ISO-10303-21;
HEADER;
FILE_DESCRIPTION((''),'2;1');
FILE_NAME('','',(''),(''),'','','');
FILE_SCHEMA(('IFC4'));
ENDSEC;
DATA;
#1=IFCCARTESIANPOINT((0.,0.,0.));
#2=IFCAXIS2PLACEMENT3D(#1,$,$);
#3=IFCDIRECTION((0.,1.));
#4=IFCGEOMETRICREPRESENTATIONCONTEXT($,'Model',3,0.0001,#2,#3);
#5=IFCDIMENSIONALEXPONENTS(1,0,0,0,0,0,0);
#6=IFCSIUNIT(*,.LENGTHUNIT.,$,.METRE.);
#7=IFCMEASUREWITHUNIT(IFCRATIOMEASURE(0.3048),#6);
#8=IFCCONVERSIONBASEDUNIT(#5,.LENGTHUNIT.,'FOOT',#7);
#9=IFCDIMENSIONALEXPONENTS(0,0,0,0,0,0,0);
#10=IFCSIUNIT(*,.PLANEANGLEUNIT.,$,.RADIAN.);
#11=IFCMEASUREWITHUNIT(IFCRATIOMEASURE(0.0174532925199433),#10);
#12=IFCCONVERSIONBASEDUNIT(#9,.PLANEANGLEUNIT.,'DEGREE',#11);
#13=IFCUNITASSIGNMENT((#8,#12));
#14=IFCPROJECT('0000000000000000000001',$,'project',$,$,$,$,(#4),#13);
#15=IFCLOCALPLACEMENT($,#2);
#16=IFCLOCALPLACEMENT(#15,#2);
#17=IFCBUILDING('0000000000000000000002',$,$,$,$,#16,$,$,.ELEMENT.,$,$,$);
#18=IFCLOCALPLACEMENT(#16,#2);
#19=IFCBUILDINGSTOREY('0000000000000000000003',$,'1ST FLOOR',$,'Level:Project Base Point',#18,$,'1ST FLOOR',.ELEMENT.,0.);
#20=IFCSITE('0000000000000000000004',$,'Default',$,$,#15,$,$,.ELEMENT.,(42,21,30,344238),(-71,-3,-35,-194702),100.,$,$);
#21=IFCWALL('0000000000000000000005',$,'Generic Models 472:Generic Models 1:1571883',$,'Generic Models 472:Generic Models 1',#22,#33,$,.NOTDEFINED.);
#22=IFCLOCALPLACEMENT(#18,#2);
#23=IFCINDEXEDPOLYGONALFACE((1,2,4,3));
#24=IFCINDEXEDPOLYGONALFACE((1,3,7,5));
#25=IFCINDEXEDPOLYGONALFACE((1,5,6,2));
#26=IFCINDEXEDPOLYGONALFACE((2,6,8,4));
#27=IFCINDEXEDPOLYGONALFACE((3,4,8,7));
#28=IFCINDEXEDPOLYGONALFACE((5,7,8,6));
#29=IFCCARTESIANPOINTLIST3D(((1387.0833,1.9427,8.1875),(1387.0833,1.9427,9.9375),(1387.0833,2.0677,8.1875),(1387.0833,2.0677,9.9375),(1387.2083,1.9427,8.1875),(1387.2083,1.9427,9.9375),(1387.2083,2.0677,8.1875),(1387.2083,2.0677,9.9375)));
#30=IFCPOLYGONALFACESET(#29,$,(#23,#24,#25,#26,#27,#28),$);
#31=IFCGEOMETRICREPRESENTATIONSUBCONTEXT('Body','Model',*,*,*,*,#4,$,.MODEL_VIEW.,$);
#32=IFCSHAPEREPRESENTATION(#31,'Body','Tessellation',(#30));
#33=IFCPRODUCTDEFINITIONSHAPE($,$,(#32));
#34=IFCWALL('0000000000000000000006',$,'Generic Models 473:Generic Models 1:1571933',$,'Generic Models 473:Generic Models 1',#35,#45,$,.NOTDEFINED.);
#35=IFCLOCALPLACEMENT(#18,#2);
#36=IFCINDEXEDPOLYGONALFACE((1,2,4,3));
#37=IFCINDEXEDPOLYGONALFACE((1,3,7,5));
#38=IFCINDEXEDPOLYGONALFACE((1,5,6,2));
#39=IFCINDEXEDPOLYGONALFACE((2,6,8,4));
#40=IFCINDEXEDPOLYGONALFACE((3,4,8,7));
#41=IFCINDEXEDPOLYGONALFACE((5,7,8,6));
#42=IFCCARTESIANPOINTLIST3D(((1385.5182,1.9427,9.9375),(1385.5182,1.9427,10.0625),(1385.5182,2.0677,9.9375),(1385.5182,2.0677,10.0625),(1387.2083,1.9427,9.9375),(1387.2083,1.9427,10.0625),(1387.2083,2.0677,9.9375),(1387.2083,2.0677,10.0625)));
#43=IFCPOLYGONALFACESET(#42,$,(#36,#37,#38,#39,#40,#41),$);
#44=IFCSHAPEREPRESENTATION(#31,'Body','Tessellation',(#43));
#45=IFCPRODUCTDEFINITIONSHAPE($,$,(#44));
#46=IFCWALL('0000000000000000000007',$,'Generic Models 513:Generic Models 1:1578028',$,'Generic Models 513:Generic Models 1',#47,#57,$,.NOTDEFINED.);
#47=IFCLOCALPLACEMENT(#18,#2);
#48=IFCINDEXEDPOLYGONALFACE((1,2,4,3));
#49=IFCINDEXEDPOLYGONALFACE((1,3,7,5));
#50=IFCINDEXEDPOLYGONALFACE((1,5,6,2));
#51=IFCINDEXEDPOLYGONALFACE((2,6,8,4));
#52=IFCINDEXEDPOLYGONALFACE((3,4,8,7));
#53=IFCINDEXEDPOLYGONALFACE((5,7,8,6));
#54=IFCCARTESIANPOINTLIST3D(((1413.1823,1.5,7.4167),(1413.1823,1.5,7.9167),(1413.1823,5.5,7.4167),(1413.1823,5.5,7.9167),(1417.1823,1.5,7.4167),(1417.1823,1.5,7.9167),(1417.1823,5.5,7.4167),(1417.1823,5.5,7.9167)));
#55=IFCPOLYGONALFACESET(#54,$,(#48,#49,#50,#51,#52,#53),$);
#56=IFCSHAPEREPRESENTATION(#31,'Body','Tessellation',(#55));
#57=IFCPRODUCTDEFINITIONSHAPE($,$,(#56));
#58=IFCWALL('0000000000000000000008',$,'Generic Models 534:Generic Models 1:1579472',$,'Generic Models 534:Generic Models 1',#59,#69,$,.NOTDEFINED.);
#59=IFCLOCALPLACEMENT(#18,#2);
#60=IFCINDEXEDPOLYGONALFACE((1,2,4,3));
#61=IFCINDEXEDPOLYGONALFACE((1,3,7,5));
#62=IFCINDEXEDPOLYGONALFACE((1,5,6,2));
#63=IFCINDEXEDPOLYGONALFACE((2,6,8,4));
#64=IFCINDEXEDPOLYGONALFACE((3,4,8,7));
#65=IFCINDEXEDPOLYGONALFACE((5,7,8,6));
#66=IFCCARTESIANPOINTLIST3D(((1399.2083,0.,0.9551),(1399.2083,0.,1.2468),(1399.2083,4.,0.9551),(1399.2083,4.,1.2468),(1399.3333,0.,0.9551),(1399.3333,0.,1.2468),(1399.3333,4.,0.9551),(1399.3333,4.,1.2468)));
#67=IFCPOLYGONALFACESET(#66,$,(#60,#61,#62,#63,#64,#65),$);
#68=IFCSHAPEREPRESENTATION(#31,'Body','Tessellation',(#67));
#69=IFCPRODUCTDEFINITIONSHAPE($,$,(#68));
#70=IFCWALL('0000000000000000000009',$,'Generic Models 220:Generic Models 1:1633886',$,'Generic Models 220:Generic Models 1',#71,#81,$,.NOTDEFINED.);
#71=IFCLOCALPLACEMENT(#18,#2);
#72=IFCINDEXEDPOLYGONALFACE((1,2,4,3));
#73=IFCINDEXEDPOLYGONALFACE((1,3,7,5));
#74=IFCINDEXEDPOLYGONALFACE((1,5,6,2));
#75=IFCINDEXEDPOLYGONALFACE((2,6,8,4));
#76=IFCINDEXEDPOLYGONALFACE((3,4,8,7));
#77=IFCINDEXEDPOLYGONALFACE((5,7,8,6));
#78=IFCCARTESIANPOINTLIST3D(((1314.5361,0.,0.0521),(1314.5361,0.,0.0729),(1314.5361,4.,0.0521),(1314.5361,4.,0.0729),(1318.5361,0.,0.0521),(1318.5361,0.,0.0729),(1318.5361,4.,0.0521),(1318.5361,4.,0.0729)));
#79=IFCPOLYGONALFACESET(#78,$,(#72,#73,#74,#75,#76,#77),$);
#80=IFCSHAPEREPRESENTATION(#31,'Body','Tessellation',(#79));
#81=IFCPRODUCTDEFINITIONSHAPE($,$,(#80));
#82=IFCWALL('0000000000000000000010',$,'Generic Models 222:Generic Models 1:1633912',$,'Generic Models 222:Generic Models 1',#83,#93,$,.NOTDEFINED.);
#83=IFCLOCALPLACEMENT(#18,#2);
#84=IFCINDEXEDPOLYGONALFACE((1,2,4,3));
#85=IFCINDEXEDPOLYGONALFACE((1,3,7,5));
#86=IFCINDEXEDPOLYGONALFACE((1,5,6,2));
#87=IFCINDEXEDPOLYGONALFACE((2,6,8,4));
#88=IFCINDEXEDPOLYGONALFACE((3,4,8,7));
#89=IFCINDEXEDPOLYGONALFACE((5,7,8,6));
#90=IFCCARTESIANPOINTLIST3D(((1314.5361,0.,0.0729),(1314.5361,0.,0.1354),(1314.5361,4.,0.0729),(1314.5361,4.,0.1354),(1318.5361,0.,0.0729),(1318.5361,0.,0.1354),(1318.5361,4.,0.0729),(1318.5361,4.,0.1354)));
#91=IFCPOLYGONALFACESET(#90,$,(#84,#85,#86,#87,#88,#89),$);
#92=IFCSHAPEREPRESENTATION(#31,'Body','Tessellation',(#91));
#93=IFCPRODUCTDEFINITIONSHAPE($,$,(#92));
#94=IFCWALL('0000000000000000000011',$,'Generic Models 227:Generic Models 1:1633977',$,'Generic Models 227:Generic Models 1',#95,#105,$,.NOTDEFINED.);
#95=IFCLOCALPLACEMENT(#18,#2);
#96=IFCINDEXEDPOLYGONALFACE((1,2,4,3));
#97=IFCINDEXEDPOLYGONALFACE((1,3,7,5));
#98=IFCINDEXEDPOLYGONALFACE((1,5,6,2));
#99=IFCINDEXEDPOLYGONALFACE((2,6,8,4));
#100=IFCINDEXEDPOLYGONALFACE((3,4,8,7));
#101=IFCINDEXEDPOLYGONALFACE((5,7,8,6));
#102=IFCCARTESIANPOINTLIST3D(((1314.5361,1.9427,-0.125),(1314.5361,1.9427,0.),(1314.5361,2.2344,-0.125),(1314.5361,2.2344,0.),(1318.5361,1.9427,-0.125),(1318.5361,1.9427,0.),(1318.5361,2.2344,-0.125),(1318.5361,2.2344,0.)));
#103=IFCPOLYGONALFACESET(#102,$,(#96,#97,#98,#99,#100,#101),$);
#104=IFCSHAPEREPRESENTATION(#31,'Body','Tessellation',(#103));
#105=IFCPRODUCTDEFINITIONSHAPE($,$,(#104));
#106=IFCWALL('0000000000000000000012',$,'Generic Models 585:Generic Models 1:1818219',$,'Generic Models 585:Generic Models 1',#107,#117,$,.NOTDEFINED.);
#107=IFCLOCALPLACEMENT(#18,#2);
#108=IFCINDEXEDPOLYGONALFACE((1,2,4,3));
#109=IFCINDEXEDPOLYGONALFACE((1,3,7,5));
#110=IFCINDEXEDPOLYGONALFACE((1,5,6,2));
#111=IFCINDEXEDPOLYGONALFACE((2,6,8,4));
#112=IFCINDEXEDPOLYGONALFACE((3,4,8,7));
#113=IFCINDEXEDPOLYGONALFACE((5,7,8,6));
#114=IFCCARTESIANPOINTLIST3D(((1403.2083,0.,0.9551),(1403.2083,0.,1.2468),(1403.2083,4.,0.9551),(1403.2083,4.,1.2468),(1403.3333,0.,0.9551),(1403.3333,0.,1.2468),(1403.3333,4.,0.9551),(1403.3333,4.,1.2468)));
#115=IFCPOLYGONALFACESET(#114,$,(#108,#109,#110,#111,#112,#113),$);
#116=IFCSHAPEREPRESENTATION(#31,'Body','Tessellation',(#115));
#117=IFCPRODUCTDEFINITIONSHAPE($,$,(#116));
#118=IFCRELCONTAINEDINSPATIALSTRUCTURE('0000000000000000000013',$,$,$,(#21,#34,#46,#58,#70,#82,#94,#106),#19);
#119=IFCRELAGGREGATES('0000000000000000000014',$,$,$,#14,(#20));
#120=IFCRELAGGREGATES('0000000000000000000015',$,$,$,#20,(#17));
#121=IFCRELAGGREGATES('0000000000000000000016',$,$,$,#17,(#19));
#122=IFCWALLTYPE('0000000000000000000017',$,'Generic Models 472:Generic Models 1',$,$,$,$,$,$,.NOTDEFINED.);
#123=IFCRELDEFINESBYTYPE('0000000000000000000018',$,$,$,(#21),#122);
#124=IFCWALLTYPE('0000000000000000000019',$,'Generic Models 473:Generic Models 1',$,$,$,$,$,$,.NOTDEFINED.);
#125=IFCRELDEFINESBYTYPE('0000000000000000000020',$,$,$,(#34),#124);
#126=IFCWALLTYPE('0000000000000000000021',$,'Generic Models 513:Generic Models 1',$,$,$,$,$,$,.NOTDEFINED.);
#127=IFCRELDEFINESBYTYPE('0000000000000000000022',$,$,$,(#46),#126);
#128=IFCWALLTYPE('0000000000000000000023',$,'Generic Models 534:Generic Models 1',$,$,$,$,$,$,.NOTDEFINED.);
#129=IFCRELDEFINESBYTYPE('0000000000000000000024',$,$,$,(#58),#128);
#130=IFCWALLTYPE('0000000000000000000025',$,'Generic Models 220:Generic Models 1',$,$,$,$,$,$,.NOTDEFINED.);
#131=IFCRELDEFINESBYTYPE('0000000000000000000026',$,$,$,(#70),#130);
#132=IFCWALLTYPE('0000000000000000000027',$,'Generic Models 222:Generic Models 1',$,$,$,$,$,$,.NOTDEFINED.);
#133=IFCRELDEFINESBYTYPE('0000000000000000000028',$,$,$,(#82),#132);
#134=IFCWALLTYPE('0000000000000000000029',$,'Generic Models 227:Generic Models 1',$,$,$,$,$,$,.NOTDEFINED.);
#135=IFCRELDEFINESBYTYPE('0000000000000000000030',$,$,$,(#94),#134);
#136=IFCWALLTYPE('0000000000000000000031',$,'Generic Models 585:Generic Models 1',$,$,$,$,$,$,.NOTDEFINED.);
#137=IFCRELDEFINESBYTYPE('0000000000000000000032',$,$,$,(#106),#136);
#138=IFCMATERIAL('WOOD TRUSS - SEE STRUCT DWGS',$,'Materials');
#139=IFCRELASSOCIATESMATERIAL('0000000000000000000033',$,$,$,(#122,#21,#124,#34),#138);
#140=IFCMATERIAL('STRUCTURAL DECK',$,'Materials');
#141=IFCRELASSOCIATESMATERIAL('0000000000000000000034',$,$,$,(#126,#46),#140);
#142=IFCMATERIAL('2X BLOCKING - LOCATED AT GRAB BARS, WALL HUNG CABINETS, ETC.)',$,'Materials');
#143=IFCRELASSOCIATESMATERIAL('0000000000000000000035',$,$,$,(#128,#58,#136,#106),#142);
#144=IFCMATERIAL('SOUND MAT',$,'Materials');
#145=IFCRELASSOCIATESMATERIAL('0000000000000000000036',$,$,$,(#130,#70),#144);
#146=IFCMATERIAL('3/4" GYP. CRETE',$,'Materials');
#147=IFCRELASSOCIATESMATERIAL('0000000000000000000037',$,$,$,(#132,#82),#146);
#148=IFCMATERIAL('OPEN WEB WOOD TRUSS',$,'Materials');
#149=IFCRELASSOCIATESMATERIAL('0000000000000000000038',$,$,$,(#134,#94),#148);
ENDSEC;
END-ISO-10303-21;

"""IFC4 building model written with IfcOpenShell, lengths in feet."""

from ifc_helpers import new_model, entity, si_unit, converted_unit, direction, frame, frame_2d, origin, origin_2d_with_axis, place, context, subcontext, project, spatial, rectangle, extrude, material, type_object, element, save


model = new_model("IFC4")

# Units and contexts
model_context = context("Model", 3, precision=0.0001, world=origin(), true_north=direction((0.0, 1.0)))
body_context = subcontext(model_context, "Body", "Model", "MODEL_VIEW")
ifc_project = project(units=[converted_unit("LENGTHUNIT", "FOOT", entity("IfcRatioMeasure", 0.3048), si_unit("LENGTHUNIT", "METRE"), dimensions=[1, 0, 0, 0, 0, 0, 0]), converted_unit("PLANEANGLEUNIT", "DEGREE", entity("IfcRatioMeasure", 0.0174532925199433), si_unit("PLANEANGLEUNIT", "RADIAN"), dimensions=[0, 0, 0, 0, 0, 0, 0])], contexts=[model_context])

# Site, building, storey
site_placement = place(None, origin())
site = spatial("IfcSite", under=ifc_project, at=site_placement, Name="Default", CompositionType="ELEMENT", RefLatitude=(42, 21, 30, 344238), RefLongitude=(-71, -3, -35, -194702), RefElevation=100.0)
building_placement = place(site_placement, origin())
building = spatial("IfcBuilding", under=site, at=building_placement, CompositionType="ELEMENT")
storey_placement = place(building_placement, origin())
storey = spatial("IfcBuildingStorey", under=building, at=storey_placement, Name="1ST FLOOR", ObjectType="Level:Project Base Point", LongName="1ST FLOOR", CompositionType="ELEMENT", Elevation=0.0)

# Walls
ifc_material_1 = material(Name="STRUCTURAL DECK", Category="Materials")
ifc_material_2 = material(Name="WOOD TRUSS - SEE STRUCT DWGS", Category="Materials")
wall_type_1 = type_object("IfcWallType", Name="Generic Models 472:Generic Models 1", PredefinedType="NOTDEFINED", material=ifc_material_2)
wall_1_placement = place(storey_placement, frame((1387.0833, 1.9427, 8.1875), z_axis=(0.0, 0.0, 1.0), x_axis=(0.0, 1.0, 0.0)))
element("IfcWall", 1, at=wall_1_placement, inside=storey, type_object=wall_type_1, material=ifc_material_2, Name="Generic Models 472:Generic Models 1:1571883", ObjectType="Generic Models 472:Generic Models 1", PredefinedType="NOTDEFINED", context=body_context, shape_type="SweptSolid", body=[
    extrude(rectangle(XDim=0.125, YDim=0.125, at=frame_2d((0.0, 0.0), x_axis=(1.0, 0.0))), frame((0.0625, -0.0625, 0.0)), (0.0, 0.0, 1.0), 1.75),
])
wall_type_2 = type_object("IfcWallType", Name="Generic Models 473:Generic Models 1", PredefinedType="NOTDEFINED", material=ifc_material_2)
wall_2_placement = place(storey_placement, frame((1385.5182, 1.9427, 9.9375)))
element("IfcWall", 2, at=wall_2_placement, inside=storey, type_object=wall_type_2, material=ifc_material_2, Name="Generic Models 473:Generic Models 1:1571933", ObjectType="Generic Models 473:Generic Models 1", PredefinedType="NOTDEFINED", context=body_context, shape_type="SweptSolid", body=[
    extrude(rectangle(XDim=0.125, YDim=1.6902, at=frame_2d((0.0, 0.0), x_axis=(1.0, 0.0))), frame((0.8451, 0.0625, 0.0), z_axis=(0.0, 0.0, 1.0), x_axis=(0.0, 1.0, 0.0)), (0.0, 0.0, 1.0), 0.125),
])
wall_type_3 = type_object("IfcWallType", Name="Generic Models 513:Generic Models 1", PredefinedType="NOTDEFINED", material=ifc_material_1)
wall_3_placement = place(storey_placement, frame((1413.1823, 1.5, 7.4167), z_axis=(0.0, 0.0, 1.0), x_axis=(0.0, 1.0, 0.0)))
element("IfcWall", 3, at=wall_3_placement, inside=storey, type_object=wall_type_3, material=ifc_material_1, Name="Generic Models 513:Generic Models 1:1578028", ObjectType="Generic Models 513:Generic Models 1", PredefinedType="NOTDEFINED", context=body_context, shape_type="SweptSolid", body=[
    extrude(rectangle(XDim=4.0, YDim=4.0, at=frame_2d((0.0, 0.0), x_axis=(1.0, 0.0))), frame((2.0, -2.0, 0.0)), (0.0, 0.0, 1.0), 0.5),
])
ifc_material_3 = material(Name="2X BLOCKING - LOCATED AT GRAB BARS, WALL HUNG CABINETS, ETC.)", Category="Materials")
wall_type_4 = type_object("IfcWallType", Name="Generic Models 534:Generic Models 1", PredefinedType="NOTDEFINED", material=ifc_material_3)
wall_4_placement = place(storey_placement, frame((1399.2083, 0.0, 0.9551), z_axis=(0.0, 0.0, 1.0), x_axis=(0.0, 1.0, 0.0)))
element("IfcWall", 4, at=wall_4_placement, inside=storey, type_object=wall_type_4, material=ifc_material_3, Name="Generic Models 534:Generic Models 1:1579472", ObjectType="Generic Models 534:Generic Models 1", PredefinedType="NOTDEFINED", context=body_context, shape_type="SweptSolid", body=[
    extrude(rectangle(XDim=4.0, YDim=0.125, at=frame_2d((0.0, 0.0), x_axis=(1.0, 0.0))), frame((2.0, -0.0625, 0.0)), (0.0, 0.0, 1.0), 0.2917),
])
ifc_material_4 = material(Name="SOUND MAT", Category="Materials")
wall_type_5 = type_object("IfcWallType", Name="Generic Models 220:Generic Models 1", PredefinedType="NOTDEFINED", material=ifc_material_4)
wall_5_placement = place(storey_placement, frame((1314.5361, 0.0, 0.0521), z_axis=(0.0, 0.0, 1.0), x_axis=(0.0, 1.0, 0.0)))
element("IfcWall", 5, at=wall_5_placement, inside=storey, type_object=wall_type_5, material=ifc_material_4, Name="Generic Models 220:Generic Models 1:1633886", ObjectType="Generic Models 220:Generic Models 1", PredefinedType="NOTDEFINED", context=body_context, shape_type="SweptSolid", body=[
    extrude(rectangle(XDim=4.0, YDim=4.0, at=origin_2d_with_axis()), frame((2.0, -2.0, 0.0)), (0.0, 0.0, 1.0), 0.0208),
])
ifc_material_5 = material(Name="3/4\" GYP. CRETE", Category="Materials")
wall_type_6 = type_object("IfcWallType", Name="Generic Models 222:Generic Models 1", PredefinedType="NOTDEFINED", material=ifc_material_5)
wall_6_placement = place(storey_placement, frame((1314.5361, 0.0, 0.0729), z_axis=(0.0, 0.0, 1.0), x_axis=(0.0, 1.0, 0.0)))
element("IfcWall", 6, at=wall_6_placement, inside=storey, type_object=wall_type_6, material=ifc_material_5, Name="Generic Models 222:Generic Models 1:1633912", ObjectType="Generic Models 222:Generic Models 1", PredefinedType="NOTDEFINED", context=body_context, shape_type="SweptSolid", body=[
    extrude(rectangle(XDim=4.0, YDim=4.0, at=origin_2d_with_axis()), frame((2.0, -2.0, 0.0)), (0.0, 0.0, 1.0), 0.0625),
])
ifc_material_6 = material(Name="OPEN WEB WOOD TRUSS", Category="Materials")
wall_type_7 = type_object("IfcWallType", Name="Generic Models 227:Generic Models 1", PredefinedType="NOTDEFINED", material=ifc_material_6)
wall_7_placement = place(storey_placement, frame((1314.5361, 1.9427, -0.125)))
element("IfcWall", 7, at=wall_7_placement, inside=storey, type_object=wall_type_7, material=ifc_material_6, Name="Generic Models 227:Generic Models 1:1633977", ObjectType="Generic Models 227:Generic Models 1", PredefinedType="NOTDEFINED", context=body_context, shape_type="SweptSolid", body=[
    extrude(rectangle(XDim=0.2917, YDim=4.0, at=frame_2d((0.0, 0.0), x_axis=(1.0, 0.0))), frame((2.0, 0.1458, 0.0), z_axis=(0.0, 0.0, 1.0), x_axis=(0.0, 1.0, 0.0)), (0.0, 0.0, 1.0), 0.125),
])
wall_type_8 = type_object("IfcWallType", Name="Generic Models 585:Generic Models 1", PredefinedType="NOTDEFINED", material=ifc_material_3)
wall_8_placement = place(storey_placement, frame((1403.2083, 0.0, 0.9551), z_axis=(0.0, 0.0, 1.0), x_axis=(0.0, 1.0, 0.0)))
element("IfcWall", 8, at=wall_8_placement, inside=storey, type_object=wall_type_8, material=ifc_material_3, Name="Generic Models 585:Generic Models 1:1818219", ObjectType="Generic Models 585:Generic Models 1", PredefinedType="NOTDEFINED", context=body_context, shape_type="SweptSolid", body=[
    extrude(rectangle(XDim=4.0, YDim=0.125, at=frame_2d((0.0, 0.0), x_axis=(1.0, 0.0))), frame((2.0, -0.0625, 0.0)), (0.0, 0.0, 1.0), 0.2917),
])

save(model, "model.ifc")
